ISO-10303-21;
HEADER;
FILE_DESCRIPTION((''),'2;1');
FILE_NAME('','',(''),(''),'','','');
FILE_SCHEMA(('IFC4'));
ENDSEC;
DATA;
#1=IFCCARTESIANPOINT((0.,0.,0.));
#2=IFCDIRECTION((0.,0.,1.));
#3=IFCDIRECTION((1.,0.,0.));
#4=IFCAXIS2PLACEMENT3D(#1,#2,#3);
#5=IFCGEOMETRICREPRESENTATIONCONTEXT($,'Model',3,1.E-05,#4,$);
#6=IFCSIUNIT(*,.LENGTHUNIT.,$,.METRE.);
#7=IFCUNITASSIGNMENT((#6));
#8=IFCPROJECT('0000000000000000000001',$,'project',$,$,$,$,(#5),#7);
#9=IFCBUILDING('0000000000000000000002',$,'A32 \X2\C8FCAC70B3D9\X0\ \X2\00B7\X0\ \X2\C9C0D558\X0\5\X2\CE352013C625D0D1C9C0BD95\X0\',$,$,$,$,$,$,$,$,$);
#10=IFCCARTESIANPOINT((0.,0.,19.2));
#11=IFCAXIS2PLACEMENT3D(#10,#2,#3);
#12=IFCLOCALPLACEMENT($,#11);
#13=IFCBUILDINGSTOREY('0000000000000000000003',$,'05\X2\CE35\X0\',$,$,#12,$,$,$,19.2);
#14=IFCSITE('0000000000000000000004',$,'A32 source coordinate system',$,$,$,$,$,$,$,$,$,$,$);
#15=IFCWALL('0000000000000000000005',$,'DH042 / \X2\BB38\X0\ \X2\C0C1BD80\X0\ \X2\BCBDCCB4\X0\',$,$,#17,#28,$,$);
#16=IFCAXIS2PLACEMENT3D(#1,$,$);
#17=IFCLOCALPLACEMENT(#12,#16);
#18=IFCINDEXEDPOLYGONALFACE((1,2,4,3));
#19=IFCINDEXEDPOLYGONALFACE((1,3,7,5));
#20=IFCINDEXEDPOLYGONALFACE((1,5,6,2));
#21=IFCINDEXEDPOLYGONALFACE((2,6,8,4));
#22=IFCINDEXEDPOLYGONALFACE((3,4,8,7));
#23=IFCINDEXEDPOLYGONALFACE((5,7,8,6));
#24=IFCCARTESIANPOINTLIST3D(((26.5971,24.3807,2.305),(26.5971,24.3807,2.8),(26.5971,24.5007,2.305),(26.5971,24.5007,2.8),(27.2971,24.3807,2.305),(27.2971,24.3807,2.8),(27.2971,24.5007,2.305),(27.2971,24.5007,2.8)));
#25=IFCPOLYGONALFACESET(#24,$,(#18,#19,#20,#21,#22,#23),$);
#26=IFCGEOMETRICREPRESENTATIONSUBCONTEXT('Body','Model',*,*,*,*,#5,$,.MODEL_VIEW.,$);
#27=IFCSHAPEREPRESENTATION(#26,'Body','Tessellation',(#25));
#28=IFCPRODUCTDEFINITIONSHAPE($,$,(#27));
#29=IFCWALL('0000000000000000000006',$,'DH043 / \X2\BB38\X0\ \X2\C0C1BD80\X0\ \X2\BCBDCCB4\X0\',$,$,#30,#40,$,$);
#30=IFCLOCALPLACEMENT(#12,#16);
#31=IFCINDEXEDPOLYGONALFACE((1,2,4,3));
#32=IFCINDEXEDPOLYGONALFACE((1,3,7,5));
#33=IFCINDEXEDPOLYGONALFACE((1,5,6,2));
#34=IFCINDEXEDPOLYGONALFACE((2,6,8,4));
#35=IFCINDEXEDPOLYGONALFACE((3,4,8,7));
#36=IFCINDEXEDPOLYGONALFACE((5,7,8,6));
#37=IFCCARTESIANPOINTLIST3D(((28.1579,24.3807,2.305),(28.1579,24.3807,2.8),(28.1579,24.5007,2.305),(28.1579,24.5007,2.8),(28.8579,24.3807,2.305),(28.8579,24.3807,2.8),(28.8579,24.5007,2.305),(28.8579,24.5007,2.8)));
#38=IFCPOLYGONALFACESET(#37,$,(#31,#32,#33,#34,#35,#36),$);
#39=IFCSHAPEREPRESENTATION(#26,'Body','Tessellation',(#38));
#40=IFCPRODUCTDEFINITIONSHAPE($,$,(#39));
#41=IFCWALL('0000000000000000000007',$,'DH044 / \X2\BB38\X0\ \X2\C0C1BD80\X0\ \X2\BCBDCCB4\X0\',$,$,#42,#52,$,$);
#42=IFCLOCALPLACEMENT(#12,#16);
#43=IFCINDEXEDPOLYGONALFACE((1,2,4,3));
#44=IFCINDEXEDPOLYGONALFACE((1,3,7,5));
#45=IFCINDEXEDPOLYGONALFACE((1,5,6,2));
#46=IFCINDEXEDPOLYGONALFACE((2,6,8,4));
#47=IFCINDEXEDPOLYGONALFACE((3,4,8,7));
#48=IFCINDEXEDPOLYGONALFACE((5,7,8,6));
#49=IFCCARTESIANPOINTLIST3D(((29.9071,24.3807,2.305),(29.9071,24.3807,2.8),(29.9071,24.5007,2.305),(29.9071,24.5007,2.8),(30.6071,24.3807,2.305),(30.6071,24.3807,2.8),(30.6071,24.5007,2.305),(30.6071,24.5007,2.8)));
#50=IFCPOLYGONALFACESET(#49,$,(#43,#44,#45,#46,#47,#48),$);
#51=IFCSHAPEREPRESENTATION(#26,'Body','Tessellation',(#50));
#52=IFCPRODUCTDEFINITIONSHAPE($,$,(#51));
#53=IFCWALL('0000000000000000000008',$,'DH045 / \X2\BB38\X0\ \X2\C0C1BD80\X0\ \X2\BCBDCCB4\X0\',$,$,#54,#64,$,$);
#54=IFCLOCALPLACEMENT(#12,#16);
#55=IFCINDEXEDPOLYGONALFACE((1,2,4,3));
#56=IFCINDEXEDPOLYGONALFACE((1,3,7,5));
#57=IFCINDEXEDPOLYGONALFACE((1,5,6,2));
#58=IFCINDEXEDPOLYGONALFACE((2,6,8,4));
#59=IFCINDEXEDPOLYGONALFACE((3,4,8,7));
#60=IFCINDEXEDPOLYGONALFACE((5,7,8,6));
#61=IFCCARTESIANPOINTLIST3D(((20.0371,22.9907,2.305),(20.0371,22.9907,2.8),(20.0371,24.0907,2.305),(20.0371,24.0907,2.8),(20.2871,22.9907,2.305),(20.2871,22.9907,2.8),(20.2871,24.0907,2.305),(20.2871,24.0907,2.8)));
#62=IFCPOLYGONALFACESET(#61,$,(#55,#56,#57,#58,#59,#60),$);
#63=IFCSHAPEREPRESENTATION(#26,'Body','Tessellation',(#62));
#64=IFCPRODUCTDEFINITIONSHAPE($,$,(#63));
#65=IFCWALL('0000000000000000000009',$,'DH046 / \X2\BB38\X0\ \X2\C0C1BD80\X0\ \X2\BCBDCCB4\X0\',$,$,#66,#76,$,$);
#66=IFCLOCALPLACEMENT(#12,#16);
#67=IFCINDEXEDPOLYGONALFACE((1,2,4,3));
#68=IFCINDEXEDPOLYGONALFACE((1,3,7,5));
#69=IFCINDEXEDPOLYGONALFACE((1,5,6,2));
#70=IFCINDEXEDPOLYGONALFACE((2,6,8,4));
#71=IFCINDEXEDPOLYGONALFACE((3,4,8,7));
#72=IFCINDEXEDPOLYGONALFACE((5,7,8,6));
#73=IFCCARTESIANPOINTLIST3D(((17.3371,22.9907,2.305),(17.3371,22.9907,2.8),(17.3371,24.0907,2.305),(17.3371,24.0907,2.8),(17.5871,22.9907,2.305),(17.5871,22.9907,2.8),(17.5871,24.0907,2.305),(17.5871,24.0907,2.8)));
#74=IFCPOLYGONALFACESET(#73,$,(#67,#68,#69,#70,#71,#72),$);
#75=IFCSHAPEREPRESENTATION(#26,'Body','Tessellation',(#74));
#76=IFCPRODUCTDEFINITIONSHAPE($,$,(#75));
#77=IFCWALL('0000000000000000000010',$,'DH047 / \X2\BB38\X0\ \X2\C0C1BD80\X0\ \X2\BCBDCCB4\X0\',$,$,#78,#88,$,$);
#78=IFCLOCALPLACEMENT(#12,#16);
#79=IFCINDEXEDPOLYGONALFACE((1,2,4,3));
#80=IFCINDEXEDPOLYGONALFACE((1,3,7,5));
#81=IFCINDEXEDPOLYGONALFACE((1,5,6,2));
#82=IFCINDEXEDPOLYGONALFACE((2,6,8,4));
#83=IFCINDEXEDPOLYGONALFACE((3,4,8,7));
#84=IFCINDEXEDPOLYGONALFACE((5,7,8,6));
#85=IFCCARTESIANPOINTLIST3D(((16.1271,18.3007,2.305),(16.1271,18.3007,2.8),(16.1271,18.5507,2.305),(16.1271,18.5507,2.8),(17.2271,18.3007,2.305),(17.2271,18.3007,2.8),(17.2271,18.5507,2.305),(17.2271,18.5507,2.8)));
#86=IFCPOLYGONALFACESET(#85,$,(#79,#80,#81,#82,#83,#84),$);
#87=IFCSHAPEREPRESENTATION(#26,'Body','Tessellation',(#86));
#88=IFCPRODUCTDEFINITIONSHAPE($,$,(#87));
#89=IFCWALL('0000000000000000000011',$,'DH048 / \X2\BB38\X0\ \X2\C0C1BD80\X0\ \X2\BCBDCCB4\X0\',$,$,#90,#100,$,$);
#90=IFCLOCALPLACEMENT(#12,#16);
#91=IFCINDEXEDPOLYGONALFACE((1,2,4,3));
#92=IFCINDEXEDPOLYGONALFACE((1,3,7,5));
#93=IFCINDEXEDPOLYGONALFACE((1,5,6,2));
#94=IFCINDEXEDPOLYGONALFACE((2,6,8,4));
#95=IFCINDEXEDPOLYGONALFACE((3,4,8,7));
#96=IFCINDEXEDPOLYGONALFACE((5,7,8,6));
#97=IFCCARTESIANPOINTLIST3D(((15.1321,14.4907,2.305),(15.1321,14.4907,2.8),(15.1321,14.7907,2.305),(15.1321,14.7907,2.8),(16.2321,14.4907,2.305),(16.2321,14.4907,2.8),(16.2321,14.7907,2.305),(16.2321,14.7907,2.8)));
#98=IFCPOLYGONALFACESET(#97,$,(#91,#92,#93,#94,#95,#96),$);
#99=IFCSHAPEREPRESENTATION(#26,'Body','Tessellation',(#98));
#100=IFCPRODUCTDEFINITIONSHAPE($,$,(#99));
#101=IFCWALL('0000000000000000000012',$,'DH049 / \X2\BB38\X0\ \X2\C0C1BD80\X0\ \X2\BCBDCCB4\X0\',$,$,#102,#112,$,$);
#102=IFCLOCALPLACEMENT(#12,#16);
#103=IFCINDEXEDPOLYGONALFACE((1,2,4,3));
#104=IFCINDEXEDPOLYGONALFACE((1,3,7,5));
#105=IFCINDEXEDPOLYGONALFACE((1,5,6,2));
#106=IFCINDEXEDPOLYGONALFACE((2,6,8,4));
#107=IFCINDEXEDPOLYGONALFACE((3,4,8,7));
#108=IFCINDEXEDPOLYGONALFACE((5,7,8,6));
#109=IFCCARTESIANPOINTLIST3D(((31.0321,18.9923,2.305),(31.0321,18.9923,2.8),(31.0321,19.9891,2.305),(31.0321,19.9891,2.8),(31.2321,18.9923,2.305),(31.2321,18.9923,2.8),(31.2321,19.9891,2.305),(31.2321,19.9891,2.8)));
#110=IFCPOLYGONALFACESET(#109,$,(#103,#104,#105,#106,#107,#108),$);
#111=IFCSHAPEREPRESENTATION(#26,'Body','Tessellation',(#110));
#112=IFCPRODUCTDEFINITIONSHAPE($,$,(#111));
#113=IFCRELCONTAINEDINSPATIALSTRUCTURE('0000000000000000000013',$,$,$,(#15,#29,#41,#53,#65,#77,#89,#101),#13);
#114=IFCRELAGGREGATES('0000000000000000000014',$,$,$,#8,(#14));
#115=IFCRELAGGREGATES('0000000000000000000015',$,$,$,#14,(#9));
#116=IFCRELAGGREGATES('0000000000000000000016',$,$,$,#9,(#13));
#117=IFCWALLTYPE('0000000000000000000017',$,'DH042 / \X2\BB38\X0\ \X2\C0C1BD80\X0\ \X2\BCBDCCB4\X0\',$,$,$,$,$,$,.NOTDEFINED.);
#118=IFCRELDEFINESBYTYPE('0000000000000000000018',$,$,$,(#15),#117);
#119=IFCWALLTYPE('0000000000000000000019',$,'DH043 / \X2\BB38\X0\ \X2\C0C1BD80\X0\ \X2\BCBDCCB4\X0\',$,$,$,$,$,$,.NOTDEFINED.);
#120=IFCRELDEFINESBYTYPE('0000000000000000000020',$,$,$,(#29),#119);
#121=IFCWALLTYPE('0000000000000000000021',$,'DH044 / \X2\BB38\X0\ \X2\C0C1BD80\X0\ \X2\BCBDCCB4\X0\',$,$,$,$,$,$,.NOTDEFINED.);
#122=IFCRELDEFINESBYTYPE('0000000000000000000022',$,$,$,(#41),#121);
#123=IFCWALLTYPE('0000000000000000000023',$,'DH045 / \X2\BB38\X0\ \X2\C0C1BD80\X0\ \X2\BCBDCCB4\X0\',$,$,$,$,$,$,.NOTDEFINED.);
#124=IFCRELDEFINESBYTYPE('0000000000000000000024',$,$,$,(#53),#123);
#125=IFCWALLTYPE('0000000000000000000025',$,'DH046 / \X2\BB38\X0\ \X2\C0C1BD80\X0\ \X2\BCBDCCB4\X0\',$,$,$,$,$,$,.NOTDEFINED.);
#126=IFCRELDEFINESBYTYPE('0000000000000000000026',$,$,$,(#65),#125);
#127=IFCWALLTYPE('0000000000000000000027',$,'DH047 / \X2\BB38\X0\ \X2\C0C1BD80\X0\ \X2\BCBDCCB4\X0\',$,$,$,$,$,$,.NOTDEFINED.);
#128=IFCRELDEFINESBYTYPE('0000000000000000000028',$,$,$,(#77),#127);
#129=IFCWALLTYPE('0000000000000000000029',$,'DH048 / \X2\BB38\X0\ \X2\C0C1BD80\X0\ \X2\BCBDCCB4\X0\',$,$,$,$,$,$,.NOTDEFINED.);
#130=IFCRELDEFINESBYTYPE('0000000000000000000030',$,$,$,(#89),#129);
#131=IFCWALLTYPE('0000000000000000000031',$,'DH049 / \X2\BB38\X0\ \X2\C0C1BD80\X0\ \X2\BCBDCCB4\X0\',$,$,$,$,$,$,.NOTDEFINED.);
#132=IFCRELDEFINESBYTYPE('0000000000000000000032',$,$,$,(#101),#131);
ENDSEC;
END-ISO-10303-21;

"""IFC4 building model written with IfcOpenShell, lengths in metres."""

from ifc_helpers import new_model, si_unit, frame, origin, origin_with_axes, place, context, subcontext, project, spatial, polyline, outline, extrude, source, transform, mapped, type_object, type_shapes, element, save


model = new_model("IFC4")

# Units and contexts
model_context = context("Model", 3, precision=1e-05, world=origin_with_axes())
body_context = subcontext(model_context, "Body", "Model", "MODEL_VIEW")
ifc_project = project(units=[si_unit("LENGTHUNIT", "METRE")], contexts=[model_context])

# Site, building, storey
site = spatial("IfcSite", under=ifc_project, Name="A32 source coordinate system")
building = spatial("IfcBuilding", under=site, Name="A32 주거동 · 지하5층–옥탑지붕")
storey_placement = place(None, frame((0.0, 0.0, 19.2), z_axis=(0.0, 0.0, 1.0), x_axis=(1.0, 0.0, 0.0)))
storey = spatial("IfcBuildingStorey", under=building, at=storey_placement, Name="05층", Elevation=19.2)

# Walls
wall_type_1 = type_object("IfcWallType", Name="DH042 / 문 상부 벽체", PredefinedType="NOTDEFINED")
shared_shape_1 = source(origin(), body_context, "Body", "SweptSolid", [
    extrude(outline(polyline([(27.2971, 24.3807), (26.5971, 24.3807), (26.5971, 24.5007), (27.2971, 24.5007), (27.2971, 24.3807)])), frame((0.0, 0.0, 2.305)), (0.0, 0.0, 1.0), 0.495),
])
type_shapes(wall_type_1, [shared_shape_1])
wall_1_placement = place(storey_placement, origin_with_axes())
element("IfcWall", 1, at=wall_1_placement, inside=storey, type_object=wall_type_1, Name="DH042 / 문 상부 벽체", context=body_context, shape_type="MappedRepresentation", body=[
    mapped(shared_shape_1, transform((0.0, 0.0, 0.0), scale=1.0)),
])
wall_type_2 = type_object("IfcWallType", Name="DH043 / 문 상부 벽체", PredefinedType="NOTDEFINED")
shared_shape_2 = source(origin(), body_context, "Body", "SweptSolid", [
    extrude(outline(polyline([(28.8579, 24.3807), (28.1579, 24.3807), (28.1579, 24.5007), (28.8579, 24.5007), (28.8579, 24.3807)])), frame((0.0, 0.0, 2.305)), (0.0, 0.0, 1.0), 0.495),
])
type_shapes(wall_type_2, [shared_shape_2])
wall_2_placement = place(storey_placement, origin_with_axes())
element("IfcWall", 2, at=wall_2_placement, inside=storey, type_object=wall_type_2, Name="DH043 / 문 상부 벽체", context=body_context, shape_type="MappedRepresentation", body=[
    mapped(shared_shape_2, transform((0.0, 0.0, 0.0), scale=1.0)),
])
wall_type_3 = type_object("IfcWallType", Name="DH044 / 문 상부 벽체", PredefinedType="NOTDEFINED")
shared_shape_3 = source(origin(), body_context, "Body", "SweptSolid", [
    extrude(outline(polyline([(30.6071, 24.3807), (29.9071, 24.3807), (29.9071, 24.5007), (30.6071, 24.5007), (30.6071, 24.3807)])), frame((0.0, 0.0, 2.305)), (0.0, 0.0, 1.0), 0.495),
])
type_shapes(wall_type_3, [shared_shape_3])
wall_3_placement = place(storey_placement, origin_with_axes())
element("IfcWall", 3, at=wall_3_placement, inside=storey, type_object=wall_type_3, Name="DH044 / 문 상부 벽체", context=body_context, shape_type="MappedRepresentation", body=[
    mapped(shared_shape_3, transform((0.0, 0.0, 0.0), scale=1.0)),
])
wall_type_4 = type_object("IfcWallType", Name="DH045 / 문 상부 벽체", PredefinedType="NOTDEFINED")
shared_shape_4 = source(origin(), body_context, "Body", "SweptSolid", [
    extrude(outline(polyline([(20.2871, 22.9907), (20.0371, 22.9907), (20.0371, 24.0907), (20.2871, 24.0907), (20.2871, 22.9907)])), frame((0.0, 0.0, 2.305)), (0.0, 0.0, 1.0), 0.495),
])
type_shapes(wall_type_4, [shared_shape_4])
wall_4_placement = place(storey_placement, origin_with_axes())
element("IfcWall", 4, at=wall_4_placement, inside=storey, type_object=wall_type_4, Name="DH045 / 문 상부 벽체", context=body_context, shape_type="MappedRepresentation", body=[
    mapped(shared_shape_4, transform((0.0, 0.0, 0.0), scale=1.0)),
])
wall_type_5 = type_object("IfcWallType", Name="DH046 / 문 상부 벽체", PredefinedType="NOTDEFINED")
shared_shape_5 = source(origin(), body_context, "Body", "SweptSolid", [
    extrude(outline(polyline([(17.5871, 22.9907), (17.3371, 22.9907), (17.3371, 24.0907), (17.5871, 24.0907), (17.5871, 22.9907)])), frame((0.0, 0.0, 2.305)), (0.0, 0.0, 1.0), 0.495),
])
type_shapes(wall_type_5, [shared_shape_5])
wall_5_placement = place(storey_placement, origin_with_axes())
element("IfcWall", 5, at=wall_5_placement, inside=storey, type_object=wall_type_5, Name="DH046 / 문 상부 벽체", context=body_context, shape_type="MappedRepresentation", body=[
    mapped(shared_shape_5, transform((0.0, 0.0, 0.0), scale=1.0)),
])
wall_type_6 = type_object("IfcWallType", Name="DH047 / 문 상부 벽체", PredefinedType="NOTDEFINED")
shared_shape_6 = source(origin(), body_context, "Body", "SweptSolid", [
    extrude(outline(polyline([(17.2271, 18.3007), (16.1271, 18.3007), (16.1271, 18.5507), (17.2271, 18.5507), (17.2271, 18.3007)])), frame((0.0, 0.0, 2.305)), (0.0, 0.0, 1.0), 0.495),
])
type_shapes(wall_type_6, [shared_shape_6])
wall_6_placement = place(storey_placement, origin_with_axes())
element("IfcWall", 6, at=wall_6_placement, inside=storey, type_object=wall_type_6, Name="DH047 / 문 상부 벽체", context=body_context, shape_type="MappedRepresentation", body=[
    mapped(shared_shape_6, transform((0.0, 0.0, 0.0), scale=1.0)),
])
wall_type_7 = type_object("IfcWallType", Name="DH048 / 문 상부 벽체", PredefinedType="NOTDEFINED")
shared_shape_7 = source(origin(), body_context, "Body", "SweptSolid", [
    extrude(outline(polyline([(15.1321, 14.7907), (16.2321, 14.7907), (16.2321, 14.4907), (15.1321, 14.4907), (15.1321, 14.7907)])), frame((0.0, 0.0, 2.305)), (0.0, 0.0, 1.0), 0.495),
])
type_shapes(wall_type_7, [shared_shape_7])
wall_7_placement = place(storey_placement, origin_with_axes())
element("IfcWall", 7, at=wall_7_placement, inside=storey, type_object=wall_type_7, Name="DH048 / 문 상부 벽체", context=body_context, shape_type="MappedRepresentation", body=[
    mapped(shared_shape_7, transform((0.0, 0.0, 0.0), scale=1.0)),
])
wall_type_8 = type_object("IfcWallType", Name="DH049 / 문 상부 벽체", PredefinedType="NOTDEFINED")
shared_shape_8 = source(origin(), body_context, "Body", "SweptSolid", [
    extrude(outline(polyline([(31.2321, 18.9923), (31.0321, 18.9923), (31.0321, 19.9891), (31.2321, 19.9891), (31.2321, 18.9923)])), frame((0.0, 0.0, 2.305)), (0.0, 0.0, 1.0), 0.495),
])
type_shapes(wall_type_8, [shared_shape_8])
wall_8_placement = place(storey_placement, origin_with_axes())
element("IfcWall", 8, at=wall_8_placement, inside=storey, type_object=wall_type_8, Name="DH049 / 문 상부 벽체", context=body_context, shape_type="MappedRepresentation", body=[
    mapped(shared_shape_8, transform((0.0, 0.0, 0.0), scale=1.0)),
])

save(model, "model.ifc")
